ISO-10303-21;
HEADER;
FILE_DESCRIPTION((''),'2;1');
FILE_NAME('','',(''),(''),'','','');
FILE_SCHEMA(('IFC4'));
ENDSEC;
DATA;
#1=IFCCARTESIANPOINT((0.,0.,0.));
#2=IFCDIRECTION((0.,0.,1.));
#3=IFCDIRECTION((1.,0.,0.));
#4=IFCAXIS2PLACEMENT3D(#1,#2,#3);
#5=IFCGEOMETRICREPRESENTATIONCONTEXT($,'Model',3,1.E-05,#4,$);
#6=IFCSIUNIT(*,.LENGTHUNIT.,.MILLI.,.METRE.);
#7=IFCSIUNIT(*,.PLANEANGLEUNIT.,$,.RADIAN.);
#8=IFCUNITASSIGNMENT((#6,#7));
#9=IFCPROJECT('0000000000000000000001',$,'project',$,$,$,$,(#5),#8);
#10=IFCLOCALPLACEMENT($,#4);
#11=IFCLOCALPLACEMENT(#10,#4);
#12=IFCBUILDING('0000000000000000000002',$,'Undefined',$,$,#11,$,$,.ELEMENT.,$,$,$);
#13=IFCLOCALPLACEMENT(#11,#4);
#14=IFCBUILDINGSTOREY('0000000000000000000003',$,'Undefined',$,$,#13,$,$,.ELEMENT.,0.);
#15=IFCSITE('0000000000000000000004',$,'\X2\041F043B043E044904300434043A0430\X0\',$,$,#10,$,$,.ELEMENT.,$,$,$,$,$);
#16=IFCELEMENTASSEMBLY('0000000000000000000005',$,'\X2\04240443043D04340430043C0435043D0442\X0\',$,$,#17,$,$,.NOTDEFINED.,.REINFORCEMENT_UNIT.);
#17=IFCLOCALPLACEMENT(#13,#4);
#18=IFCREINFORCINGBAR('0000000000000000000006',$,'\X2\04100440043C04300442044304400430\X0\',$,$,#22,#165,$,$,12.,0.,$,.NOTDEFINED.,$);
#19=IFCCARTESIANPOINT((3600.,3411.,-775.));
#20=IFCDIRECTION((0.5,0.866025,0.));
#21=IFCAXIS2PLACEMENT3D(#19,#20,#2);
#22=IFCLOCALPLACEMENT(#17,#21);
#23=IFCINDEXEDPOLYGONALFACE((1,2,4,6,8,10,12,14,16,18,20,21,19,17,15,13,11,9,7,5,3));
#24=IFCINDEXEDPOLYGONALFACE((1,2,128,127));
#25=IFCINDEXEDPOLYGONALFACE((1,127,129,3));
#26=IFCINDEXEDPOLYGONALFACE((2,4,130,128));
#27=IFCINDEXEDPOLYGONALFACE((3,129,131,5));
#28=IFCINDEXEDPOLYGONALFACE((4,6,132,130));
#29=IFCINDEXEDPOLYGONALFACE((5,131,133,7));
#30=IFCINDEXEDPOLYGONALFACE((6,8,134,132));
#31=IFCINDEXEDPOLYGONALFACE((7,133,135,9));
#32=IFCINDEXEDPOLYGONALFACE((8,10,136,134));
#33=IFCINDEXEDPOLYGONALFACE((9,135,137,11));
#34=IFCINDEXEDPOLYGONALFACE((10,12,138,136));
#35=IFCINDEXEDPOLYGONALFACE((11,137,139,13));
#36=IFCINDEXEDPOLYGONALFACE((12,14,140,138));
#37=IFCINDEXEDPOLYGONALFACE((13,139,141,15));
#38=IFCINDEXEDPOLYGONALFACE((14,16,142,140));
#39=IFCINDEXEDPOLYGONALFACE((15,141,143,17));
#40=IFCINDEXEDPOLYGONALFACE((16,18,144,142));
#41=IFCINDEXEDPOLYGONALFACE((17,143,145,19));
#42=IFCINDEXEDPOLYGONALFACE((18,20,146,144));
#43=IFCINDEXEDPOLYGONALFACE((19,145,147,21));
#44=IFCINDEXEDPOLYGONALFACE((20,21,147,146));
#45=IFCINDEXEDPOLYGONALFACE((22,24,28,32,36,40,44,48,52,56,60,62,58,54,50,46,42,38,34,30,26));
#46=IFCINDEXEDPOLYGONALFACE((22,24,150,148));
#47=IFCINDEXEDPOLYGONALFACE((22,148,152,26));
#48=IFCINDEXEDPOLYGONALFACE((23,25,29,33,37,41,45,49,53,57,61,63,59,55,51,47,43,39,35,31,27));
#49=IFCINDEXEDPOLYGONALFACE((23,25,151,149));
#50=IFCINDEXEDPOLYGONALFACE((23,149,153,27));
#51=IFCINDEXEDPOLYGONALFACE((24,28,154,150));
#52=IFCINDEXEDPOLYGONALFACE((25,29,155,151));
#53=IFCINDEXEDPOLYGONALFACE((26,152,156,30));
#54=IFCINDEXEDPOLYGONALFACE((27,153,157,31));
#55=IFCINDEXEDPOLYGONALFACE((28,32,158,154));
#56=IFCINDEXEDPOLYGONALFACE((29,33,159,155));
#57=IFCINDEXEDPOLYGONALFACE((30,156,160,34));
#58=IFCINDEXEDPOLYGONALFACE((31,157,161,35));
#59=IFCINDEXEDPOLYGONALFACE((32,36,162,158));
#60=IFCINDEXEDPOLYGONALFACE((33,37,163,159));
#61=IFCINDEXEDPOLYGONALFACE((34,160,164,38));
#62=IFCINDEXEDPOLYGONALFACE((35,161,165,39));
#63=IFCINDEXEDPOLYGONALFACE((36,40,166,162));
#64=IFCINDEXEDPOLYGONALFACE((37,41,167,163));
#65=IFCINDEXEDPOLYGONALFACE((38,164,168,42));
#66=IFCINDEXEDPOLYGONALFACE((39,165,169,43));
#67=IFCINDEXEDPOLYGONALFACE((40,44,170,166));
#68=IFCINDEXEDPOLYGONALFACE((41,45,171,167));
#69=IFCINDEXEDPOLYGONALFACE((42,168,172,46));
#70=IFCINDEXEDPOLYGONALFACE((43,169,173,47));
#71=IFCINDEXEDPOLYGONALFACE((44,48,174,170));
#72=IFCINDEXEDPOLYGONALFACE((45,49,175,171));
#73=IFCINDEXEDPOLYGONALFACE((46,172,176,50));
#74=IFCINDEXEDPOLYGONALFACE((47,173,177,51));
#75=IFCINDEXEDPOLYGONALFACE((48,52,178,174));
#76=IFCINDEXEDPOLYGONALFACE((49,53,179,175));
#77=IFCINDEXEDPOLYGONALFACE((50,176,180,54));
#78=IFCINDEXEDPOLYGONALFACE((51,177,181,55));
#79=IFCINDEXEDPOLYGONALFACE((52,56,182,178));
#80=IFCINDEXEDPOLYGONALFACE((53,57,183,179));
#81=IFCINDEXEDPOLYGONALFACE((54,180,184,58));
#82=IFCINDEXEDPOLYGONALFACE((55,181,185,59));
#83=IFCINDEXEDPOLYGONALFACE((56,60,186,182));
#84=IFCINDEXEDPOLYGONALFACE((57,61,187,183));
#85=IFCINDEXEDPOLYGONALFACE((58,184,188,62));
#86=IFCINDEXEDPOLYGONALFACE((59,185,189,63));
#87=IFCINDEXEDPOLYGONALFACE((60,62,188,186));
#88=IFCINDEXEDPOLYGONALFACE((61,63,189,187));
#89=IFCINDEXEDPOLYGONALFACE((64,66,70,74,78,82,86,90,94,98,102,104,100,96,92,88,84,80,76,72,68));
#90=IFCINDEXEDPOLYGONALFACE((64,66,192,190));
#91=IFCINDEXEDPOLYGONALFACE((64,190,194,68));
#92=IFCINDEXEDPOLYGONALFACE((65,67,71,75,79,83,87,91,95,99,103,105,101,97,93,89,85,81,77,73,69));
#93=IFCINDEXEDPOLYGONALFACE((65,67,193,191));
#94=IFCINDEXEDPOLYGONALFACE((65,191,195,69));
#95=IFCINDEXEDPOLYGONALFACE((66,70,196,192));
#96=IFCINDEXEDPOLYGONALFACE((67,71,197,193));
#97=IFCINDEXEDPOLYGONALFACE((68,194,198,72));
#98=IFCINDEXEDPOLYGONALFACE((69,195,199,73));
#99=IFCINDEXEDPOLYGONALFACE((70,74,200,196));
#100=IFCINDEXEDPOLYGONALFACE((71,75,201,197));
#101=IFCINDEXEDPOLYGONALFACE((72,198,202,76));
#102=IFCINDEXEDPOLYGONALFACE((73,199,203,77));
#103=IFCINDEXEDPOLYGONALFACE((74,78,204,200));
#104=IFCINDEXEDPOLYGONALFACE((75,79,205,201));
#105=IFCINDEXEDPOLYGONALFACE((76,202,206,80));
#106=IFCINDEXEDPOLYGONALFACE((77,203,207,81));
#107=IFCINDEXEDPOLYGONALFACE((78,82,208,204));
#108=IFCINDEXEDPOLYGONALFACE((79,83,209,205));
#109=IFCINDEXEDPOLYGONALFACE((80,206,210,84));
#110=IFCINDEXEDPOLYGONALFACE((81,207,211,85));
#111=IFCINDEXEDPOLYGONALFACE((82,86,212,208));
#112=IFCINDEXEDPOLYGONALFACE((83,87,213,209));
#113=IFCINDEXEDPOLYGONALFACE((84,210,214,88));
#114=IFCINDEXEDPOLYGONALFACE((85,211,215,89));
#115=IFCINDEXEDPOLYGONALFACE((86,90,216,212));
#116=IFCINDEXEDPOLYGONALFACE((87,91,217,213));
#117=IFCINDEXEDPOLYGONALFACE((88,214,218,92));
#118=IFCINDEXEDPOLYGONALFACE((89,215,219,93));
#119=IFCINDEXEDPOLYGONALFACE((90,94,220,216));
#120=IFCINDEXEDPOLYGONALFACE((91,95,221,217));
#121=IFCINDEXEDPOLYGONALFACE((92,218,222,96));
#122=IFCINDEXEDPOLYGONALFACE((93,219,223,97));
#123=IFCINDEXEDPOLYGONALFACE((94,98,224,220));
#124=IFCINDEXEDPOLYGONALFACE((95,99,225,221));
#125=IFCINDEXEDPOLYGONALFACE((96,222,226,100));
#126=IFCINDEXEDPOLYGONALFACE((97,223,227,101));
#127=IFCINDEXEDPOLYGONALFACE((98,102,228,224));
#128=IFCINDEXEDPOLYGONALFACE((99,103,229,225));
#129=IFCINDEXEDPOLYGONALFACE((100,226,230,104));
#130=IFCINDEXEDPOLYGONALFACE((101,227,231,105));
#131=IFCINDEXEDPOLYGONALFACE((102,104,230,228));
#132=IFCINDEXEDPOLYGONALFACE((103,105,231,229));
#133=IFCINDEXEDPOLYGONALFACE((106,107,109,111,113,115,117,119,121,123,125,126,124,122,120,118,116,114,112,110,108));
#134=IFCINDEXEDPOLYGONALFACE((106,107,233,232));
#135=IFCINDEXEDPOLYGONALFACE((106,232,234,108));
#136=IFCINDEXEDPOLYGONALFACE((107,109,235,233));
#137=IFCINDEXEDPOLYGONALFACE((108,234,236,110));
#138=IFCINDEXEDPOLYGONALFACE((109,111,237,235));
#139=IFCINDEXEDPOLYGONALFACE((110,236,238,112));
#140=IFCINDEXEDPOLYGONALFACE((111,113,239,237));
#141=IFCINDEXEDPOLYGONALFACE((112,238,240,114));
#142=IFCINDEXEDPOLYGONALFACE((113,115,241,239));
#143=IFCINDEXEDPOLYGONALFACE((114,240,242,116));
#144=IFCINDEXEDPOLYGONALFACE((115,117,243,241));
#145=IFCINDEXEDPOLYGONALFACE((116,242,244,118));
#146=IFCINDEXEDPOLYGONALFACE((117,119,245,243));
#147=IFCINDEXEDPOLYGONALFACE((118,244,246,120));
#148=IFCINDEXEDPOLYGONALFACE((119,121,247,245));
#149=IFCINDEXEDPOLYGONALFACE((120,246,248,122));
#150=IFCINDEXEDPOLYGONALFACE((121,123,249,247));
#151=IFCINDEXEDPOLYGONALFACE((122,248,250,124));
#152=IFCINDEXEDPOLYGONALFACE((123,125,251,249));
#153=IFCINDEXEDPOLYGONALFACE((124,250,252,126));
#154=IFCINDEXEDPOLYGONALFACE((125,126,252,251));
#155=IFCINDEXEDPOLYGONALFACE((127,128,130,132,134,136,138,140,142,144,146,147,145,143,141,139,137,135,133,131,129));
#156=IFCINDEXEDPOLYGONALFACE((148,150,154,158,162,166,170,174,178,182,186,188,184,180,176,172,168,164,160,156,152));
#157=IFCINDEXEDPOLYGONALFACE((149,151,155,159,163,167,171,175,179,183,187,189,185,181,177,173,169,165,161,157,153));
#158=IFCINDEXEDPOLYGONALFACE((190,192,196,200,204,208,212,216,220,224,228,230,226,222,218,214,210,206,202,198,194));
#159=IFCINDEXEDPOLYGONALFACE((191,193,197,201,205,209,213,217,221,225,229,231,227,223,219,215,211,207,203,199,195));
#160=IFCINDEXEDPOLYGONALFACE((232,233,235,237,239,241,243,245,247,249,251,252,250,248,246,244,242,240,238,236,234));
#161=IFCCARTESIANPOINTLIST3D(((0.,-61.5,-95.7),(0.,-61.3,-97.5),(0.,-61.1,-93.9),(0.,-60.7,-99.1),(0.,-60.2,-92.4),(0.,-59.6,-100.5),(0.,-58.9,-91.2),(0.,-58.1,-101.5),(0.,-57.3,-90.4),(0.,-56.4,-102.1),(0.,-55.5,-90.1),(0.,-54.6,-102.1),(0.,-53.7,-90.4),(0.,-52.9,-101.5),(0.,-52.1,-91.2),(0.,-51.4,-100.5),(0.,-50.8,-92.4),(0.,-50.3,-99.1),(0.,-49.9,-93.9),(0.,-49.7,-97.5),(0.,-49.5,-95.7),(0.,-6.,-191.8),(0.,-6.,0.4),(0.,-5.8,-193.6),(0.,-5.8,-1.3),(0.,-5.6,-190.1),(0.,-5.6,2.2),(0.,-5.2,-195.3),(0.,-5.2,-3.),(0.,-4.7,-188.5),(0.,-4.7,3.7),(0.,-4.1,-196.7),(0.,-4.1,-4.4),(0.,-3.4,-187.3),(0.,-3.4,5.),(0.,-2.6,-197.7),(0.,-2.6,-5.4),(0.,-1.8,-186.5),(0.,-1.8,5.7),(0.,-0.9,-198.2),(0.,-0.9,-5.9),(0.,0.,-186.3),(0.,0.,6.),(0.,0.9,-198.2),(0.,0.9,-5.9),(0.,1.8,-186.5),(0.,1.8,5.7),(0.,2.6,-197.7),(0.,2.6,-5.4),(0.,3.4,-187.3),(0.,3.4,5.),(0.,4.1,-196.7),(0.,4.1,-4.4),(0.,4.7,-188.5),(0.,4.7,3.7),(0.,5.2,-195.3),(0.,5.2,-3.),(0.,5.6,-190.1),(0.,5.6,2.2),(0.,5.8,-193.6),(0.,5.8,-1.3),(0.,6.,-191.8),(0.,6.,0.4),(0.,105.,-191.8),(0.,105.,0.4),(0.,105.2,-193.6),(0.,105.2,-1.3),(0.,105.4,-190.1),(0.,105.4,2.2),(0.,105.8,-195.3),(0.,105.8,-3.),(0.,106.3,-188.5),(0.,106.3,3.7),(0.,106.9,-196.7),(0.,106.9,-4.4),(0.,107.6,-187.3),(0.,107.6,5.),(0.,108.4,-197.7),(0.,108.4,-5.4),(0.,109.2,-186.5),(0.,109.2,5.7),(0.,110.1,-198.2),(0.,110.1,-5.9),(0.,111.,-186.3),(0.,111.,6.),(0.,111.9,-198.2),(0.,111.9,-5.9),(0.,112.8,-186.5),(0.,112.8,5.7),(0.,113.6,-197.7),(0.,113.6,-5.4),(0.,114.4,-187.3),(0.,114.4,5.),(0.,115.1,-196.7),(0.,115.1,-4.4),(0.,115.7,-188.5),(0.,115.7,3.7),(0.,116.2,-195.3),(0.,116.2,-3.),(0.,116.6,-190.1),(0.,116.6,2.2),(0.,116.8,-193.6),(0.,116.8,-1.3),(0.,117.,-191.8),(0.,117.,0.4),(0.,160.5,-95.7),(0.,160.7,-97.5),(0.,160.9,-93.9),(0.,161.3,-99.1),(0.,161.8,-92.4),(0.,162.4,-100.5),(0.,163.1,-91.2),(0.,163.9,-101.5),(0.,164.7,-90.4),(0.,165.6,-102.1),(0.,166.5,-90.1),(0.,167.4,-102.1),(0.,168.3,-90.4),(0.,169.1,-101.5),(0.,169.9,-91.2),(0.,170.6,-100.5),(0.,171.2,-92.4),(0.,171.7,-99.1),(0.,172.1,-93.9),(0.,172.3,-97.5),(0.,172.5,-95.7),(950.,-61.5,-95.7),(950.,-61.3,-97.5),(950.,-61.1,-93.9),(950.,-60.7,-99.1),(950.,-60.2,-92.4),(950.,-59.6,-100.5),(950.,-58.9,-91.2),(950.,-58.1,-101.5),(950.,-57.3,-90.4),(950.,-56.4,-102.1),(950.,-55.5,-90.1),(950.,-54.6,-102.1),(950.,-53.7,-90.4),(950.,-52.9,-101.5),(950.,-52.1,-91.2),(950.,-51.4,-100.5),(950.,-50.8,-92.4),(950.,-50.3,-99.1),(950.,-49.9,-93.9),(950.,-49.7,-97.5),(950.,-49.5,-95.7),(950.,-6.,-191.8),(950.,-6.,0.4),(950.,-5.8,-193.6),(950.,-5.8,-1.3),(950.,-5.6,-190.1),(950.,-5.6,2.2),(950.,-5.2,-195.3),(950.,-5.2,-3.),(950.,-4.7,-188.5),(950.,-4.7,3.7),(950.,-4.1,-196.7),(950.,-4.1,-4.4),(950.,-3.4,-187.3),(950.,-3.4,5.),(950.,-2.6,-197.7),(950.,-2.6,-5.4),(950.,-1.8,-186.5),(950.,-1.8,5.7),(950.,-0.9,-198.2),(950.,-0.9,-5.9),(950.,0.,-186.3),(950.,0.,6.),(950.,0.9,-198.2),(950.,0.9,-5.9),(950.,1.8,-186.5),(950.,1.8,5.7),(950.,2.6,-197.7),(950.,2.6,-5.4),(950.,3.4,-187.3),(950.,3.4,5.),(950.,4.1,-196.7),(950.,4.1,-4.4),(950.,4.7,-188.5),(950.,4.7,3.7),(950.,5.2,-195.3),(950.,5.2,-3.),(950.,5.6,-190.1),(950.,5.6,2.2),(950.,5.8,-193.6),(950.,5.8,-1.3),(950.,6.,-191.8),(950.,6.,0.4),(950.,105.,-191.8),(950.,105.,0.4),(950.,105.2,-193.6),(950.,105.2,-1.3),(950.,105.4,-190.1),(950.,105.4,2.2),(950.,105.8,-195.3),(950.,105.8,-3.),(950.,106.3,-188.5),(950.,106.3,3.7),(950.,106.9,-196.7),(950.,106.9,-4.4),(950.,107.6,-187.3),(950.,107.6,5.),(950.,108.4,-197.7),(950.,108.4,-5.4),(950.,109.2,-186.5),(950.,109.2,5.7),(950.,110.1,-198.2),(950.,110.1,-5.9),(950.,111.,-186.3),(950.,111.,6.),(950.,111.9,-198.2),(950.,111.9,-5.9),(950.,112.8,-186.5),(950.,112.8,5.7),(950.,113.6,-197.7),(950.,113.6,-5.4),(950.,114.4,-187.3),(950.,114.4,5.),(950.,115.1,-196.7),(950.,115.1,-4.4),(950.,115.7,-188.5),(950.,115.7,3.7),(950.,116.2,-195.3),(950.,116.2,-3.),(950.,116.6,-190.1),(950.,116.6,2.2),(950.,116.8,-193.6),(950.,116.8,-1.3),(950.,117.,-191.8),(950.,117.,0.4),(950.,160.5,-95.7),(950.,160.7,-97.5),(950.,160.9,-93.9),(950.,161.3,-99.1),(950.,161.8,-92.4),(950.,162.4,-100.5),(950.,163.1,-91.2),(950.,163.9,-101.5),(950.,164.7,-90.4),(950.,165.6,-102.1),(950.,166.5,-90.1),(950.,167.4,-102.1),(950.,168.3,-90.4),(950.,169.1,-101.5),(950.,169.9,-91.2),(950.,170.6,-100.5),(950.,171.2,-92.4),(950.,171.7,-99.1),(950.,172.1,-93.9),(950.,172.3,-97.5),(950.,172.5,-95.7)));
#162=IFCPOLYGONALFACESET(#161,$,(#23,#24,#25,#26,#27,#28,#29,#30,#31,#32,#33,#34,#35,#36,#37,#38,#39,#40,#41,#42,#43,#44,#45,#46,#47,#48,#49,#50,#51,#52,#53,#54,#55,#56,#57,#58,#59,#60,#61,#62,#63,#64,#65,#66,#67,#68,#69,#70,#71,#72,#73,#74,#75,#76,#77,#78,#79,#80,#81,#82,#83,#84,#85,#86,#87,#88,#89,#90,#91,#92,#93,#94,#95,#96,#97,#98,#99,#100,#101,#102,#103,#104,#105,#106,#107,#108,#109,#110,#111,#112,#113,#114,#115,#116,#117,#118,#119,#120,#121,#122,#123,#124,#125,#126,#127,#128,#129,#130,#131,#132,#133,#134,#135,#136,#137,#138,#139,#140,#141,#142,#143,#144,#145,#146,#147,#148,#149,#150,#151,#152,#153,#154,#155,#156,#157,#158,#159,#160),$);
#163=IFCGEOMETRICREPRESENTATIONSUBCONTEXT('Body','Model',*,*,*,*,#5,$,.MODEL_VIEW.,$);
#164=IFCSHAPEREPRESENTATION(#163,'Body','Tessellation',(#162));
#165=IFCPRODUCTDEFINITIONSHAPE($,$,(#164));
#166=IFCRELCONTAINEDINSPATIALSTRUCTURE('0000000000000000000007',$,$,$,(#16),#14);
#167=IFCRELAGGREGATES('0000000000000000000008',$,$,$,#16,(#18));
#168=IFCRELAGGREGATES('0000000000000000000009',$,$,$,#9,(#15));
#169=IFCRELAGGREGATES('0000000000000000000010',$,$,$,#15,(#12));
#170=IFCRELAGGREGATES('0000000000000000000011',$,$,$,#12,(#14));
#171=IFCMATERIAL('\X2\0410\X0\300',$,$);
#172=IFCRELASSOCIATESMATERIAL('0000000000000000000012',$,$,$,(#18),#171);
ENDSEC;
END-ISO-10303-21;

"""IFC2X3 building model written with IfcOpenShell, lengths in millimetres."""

from ifc_helpers import new_model, entity, si_unit, frame, origin_with_axes, place, context, subcontext, project, spatial, source, transform, mapped, material, element, aggregate, save


model = new_model("IFC2X3")

# Units and contexts
model_context = context("Model", 3, precision=1e-05, world=origin_with_axes())
body_context = subcontext(model_context, "Body", "Model", "MODEL_VIEW")
ifc_project = project(units=[si_unit("LENGTHUNIT", "METRE", prefix="MILLI"), si_unit("PLANEANGLEUNIT", "RADIAN")], contexts=[model_context])

# Site, building, storey
site_placement = place(None, origin_with_axes())
site = spatial("IfcSite", under=ifc_project, at=site_placement, Name="Площадка", CompositionType="ELEMENT")
building_placement = place(site_placement, origin_with_axes())
building = spatial("IfcBuilding", under=site, at=building_placement, Name="Undefined", CompositionType="ELEMENT")
storey_placement = place(building_placement, origin_with_axes())
storey = spatial("IfcBuildingStorey", under=building, at=storey_placement, Name="Undefined", CompositionType="ELEMENT", Elevation=0.0)

# Element assembly
assembly_1_placement = place(storey_placement, origin_with_axes())
assembly_1 = element("IfcElementAssembly", 1, at=assembly_1_placement, inside=storey, Name="Фундамент", AssemblyPlace="NOTDEFINED", PredefinedType="REINFORCEMENT_UNIT")

# Reinforcing bar
ifc_material_1 = material(Name="А300")
shared_shape_1 = source(origin_with_axes(), body_context, "Body", "AdvancedSweptSolid", [
    entity("IfcSweptDiskSolid", entity("IfcTrimmedCurve", entity("IfcLine", entity("IfcCartesianPoint", [0.0, 0.0, 0.0]), entity("IfcVector", entity("IfcDirection", [1.0, 0.0, 0.0]), 1.0)), [entity("IfcParameterValue", 0.0)], [entity("IfcParameterValue", 950.0)], True, "PARAMETER"), 6.0, None, 0.0, 950.0),
])
shared_shape_2 = source(origin_with_axes(), body_context, "Body", "AdvancedSweptSolid", [
    entity("IfcSweptDiskSolid", entity("IfcTrimmedCurve", entity("IfcLine", entity("IfcCartesianPoint", [0.0, 0.0, 0.0]), entity("IfcVector", entity("IfcDirection", [1.0, 0.0, 0.0]), 1.0)), [entity("IfcParameterValue", 0.0)], [entity("IfcParameterValue", 950.0)], True, "PARAMETER"), 6.0, None, 0.0, 950.0),
])
shared_shape_3 = source(origin_with_axes(), body_context, "Body", "AdvancedSweptSolid", [
    entity("IfcSweptDiskSolid", entity("IfcTrimmedCurve", entity("IfcLine", entity("IfcCartesianPoint", [0.0, 0.0, 0.0]), entity("IfcVector", entity("IfcDirection", [1.0, 0.0, 0.0]), 1.0)), [entity("IfcParameterValue", 0.0)], [entity("IfcParameterValue", 950.0)], True, "PARAMETER"), 6.0, None, 0.0, 950.0),
])
shared_shape_4 = source(origin_with_axes(), body_context, "Body", "AdvancedSweptSolid", [
    entity("IfcSweptDiskSolid", entity("IfcTrimmedCurve", entity("IfcLine", entity("IfcCartesianPoint", [0.0, 0.0, 0.0]), entity("IfcVector", entity("IfcDirection", [1.0, 0.0, 0.0]), 1.0)), [entity("IfcParameterValue", 0.0)], [entity("IfcParameterValue", 950.0)], True, "PARAMETER"), 6.0, None, 0.0, 950.0),
])
shared_shape_5 = source(origin_with_axes(), body_context, "Body", "AdvancedSweptSolid", [
    entity("IfcSweptDiskSolid", entity("IfcTrimmedCurve", entity("IfcLine", entity("IfcCartesianPoint", [0.0, 0.0, 0.0]), entity("IfcVector", entity("IfcDirection", [1.0, 0.0, 0.0]), 1.0)), [entity("IfcParameterValue", 0.0)], [entity("IfcParameterValue", 950.0)], True, "PARAMETER"), 6.0, None, 0.0, 950.0),
])
shared_shape_6 = source(origin_with_axes(), body_context, "Body", "AdvancedSweptSolid", [
    entity("IfcSweptDiskSolid", entity("IfcTrimmedCurve", entity("IfcLine", entity("IfcCartesianPoint", [0.0, 0.0, 0.0]), entity("IfcVector", entity("IfcDirection", [1.0, 0.0, 0.0]), 1.0)), [entity("IfcParameterValue", 0.0)], [entity("IfcParameterValue", 950.0)], True, "PARAMETER"), 6.0, None, 0.0, 950.0),
])
reinforcing_bar_1_placement = place(assembly_1_placement, frame((3600.0, 3411.0, -775.0), z_axis=(0.5, 0.866025, 0.0), x_axis=(0.0, 0.0, 1.0)))
reinforcing_bar_1 = element("IfcReinforcingBar", 2, at=reinforcing_bar_1_placement, material=ifc_material_1, Name="Арматура", BarRole="NOTDEFINED", CrossSectionArea=0.0, NominalDiameter=12.0, context=body_context, shape_type="MappedRepresentation", body=[
    mapped(shared_shape_1, transform((0.0, 0.0, 0.0))),
    mapped(shared_shape_2, transform((0.0, -55.5, -96.1))),
    mapped(shared_shape_3, transform((0.0, 0.0, -192.3))),
    mapped(shared_shape_4, transform((0.0, 111.0, -192.3))),
    mapped(shared_shape_5, transform((0.0, 166.5, -96.1))),
    mapped(shared_shape_6, transform((0.0, 111.0, 0.0))),
])
aggregate(assembly_1, [reinforcing_bar_1])

save(model, "model.ifc")
